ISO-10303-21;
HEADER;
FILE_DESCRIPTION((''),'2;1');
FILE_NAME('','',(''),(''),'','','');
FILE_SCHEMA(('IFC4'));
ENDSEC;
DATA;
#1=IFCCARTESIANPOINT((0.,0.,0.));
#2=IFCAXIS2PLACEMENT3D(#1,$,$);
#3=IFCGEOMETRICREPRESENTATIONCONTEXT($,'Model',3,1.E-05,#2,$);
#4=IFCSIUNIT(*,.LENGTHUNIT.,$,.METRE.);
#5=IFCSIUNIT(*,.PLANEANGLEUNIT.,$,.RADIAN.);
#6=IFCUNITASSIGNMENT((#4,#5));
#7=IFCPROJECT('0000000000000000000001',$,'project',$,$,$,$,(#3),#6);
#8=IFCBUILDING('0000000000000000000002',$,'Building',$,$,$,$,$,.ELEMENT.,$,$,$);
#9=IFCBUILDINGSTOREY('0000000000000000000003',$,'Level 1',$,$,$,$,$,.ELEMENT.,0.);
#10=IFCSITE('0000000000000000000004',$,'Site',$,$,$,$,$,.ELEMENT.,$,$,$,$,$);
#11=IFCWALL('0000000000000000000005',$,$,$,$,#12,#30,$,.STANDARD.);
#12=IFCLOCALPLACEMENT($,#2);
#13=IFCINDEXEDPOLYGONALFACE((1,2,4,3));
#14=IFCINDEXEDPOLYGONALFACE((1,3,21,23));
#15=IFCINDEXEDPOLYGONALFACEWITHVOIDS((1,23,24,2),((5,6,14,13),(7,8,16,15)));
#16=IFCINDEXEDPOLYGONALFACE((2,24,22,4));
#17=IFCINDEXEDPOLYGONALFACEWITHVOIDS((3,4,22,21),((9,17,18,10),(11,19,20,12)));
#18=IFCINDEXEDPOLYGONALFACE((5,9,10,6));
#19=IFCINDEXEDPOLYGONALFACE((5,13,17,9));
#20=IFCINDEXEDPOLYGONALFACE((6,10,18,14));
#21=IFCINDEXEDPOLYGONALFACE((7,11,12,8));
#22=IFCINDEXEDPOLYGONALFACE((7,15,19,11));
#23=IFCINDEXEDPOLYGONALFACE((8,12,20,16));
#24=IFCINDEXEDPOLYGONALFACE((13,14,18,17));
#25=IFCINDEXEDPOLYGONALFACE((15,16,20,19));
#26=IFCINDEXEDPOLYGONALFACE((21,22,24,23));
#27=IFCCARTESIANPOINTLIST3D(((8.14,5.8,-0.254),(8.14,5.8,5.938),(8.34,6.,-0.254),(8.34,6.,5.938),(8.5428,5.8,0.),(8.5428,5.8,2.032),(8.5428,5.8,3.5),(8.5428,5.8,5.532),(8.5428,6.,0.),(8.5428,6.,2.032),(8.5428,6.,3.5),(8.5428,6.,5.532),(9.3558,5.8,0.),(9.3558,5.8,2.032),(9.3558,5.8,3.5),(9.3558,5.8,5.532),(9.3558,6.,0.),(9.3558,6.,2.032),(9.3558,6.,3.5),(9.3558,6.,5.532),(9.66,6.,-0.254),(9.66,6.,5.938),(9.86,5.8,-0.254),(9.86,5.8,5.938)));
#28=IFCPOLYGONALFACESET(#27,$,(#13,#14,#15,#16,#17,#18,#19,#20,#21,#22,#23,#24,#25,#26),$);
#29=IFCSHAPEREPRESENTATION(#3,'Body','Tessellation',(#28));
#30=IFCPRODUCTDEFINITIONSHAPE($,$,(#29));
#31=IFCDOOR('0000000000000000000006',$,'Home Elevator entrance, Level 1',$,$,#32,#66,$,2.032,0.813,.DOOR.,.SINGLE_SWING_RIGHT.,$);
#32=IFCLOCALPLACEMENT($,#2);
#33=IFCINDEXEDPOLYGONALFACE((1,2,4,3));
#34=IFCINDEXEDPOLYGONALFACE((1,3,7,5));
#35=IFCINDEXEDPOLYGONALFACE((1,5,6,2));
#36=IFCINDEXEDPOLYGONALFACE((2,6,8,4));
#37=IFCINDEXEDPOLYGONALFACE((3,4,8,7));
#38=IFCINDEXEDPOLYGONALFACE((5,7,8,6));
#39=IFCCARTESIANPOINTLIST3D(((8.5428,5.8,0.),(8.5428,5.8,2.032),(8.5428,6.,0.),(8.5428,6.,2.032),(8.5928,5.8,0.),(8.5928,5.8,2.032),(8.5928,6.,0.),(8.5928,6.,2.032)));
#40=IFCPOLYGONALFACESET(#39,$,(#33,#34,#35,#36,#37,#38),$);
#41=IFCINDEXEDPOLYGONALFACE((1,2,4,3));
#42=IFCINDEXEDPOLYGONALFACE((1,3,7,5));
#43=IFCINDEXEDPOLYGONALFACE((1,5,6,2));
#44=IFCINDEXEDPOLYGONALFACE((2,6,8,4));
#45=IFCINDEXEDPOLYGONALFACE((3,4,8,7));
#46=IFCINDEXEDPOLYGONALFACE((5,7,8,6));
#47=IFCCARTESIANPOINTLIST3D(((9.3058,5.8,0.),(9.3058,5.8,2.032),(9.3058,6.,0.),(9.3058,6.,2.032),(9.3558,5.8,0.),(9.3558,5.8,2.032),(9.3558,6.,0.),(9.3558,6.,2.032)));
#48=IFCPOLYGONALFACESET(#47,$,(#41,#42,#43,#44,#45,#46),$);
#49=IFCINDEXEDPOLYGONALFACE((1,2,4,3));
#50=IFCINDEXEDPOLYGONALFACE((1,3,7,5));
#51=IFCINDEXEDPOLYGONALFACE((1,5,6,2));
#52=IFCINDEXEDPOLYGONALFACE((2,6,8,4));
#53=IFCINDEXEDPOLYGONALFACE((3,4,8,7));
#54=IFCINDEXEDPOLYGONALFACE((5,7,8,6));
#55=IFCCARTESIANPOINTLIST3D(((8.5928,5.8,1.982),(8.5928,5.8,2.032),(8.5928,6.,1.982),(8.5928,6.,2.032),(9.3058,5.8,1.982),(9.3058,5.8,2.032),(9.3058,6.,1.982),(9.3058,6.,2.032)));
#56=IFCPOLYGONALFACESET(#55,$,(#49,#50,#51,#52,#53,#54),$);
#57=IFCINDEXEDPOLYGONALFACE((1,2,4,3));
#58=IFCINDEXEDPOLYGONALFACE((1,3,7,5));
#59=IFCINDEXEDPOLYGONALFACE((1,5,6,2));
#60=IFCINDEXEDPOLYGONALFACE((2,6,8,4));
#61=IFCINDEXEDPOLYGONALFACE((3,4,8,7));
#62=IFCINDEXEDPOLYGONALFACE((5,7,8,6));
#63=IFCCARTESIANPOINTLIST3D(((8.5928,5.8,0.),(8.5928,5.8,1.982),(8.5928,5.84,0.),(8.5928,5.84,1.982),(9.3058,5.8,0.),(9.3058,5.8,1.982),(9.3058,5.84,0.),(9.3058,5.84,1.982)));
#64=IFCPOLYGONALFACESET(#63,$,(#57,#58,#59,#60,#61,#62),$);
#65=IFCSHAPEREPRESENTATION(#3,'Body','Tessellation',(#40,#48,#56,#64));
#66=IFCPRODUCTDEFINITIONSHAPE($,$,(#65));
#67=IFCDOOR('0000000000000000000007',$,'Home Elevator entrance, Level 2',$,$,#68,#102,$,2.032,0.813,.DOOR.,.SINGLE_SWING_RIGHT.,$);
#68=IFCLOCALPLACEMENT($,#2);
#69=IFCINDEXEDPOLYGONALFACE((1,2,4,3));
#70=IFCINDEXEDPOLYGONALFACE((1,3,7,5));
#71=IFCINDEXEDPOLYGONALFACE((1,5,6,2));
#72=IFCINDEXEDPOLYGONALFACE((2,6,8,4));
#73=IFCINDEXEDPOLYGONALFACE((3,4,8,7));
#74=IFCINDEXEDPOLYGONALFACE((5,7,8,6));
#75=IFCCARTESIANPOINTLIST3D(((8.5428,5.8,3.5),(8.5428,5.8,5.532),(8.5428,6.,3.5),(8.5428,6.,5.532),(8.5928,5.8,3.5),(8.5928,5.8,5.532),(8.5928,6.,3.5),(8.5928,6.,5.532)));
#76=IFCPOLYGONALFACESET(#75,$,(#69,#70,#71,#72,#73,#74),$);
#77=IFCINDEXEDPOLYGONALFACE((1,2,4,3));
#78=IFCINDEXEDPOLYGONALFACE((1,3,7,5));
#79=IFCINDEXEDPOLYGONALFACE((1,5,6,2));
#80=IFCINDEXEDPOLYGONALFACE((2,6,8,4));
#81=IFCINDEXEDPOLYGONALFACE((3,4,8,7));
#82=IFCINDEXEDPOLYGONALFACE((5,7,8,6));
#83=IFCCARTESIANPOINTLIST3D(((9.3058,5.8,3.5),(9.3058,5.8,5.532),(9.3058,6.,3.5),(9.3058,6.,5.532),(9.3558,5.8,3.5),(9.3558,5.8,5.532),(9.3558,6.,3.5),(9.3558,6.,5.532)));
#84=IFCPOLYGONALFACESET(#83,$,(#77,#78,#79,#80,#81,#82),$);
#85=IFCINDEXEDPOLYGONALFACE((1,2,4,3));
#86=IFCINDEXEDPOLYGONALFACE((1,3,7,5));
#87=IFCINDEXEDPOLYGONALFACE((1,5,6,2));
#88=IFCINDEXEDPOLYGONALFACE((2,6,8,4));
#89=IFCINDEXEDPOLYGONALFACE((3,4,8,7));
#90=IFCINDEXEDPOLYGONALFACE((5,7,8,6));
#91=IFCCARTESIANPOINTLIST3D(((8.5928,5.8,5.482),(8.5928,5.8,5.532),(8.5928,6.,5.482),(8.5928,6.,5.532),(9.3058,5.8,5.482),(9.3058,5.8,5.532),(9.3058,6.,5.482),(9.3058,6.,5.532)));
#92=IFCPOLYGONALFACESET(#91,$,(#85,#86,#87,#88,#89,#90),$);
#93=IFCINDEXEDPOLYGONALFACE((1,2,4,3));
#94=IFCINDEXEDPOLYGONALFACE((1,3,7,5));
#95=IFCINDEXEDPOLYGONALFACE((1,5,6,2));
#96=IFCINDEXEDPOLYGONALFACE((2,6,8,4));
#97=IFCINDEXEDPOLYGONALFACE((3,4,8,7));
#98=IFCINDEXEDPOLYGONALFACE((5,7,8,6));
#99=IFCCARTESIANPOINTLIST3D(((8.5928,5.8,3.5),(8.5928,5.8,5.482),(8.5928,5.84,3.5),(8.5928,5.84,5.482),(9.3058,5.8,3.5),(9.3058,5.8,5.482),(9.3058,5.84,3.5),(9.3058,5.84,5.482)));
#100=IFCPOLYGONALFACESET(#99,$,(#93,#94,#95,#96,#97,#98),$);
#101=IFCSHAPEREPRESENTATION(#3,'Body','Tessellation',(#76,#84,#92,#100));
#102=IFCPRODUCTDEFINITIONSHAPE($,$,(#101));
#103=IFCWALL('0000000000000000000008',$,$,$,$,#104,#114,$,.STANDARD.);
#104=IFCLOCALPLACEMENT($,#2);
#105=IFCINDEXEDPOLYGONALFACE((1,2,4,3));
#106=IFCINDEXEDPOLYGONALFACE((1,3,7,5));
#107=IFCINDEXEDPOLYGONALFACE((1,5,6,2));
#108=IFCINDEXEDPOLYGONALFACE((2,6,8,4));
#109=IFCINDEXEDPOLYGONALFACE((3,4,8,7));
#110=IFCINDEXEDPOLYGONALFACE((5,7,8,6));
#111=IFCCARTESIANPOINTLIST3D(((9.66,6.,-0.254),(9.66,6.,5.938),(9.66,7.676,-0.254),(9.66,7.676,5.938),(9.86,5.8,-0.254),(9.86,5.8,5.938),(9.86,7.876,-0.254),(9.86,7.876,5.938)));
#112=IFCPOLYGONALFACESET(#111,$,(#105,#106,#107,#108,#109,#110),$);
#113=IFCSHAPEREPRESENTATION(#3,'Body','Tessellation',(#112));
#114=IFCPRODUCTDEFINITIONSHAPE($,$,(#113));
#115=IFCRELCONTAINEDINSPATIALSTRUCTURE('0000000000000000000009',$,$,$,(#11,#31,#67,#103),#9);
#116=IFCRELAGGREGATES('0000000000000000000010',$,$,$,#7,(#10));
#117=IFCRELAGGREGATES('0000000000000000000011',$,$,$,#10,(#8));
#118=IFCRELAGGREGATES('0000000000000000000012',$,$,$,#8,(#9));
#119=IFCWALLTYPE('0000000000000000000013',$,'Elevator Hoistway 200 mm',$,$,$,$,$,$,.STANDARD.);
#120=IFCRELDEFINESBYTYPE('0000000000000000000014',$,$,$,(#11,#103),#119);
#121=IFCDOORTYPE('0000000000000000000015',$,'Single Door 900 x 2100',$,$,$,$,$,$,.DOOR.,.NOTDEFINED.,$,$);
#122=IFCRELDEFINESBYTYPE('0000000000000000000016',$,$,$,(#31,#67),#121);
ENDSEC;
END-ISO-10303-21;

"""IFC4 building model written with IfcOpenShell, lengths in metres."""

from ifc_helpers import new_model, si_unit, frame, frame_2d, origin, origin_with_axes, origin_2d, place, context, project, spatial, polyline, rectangle, outline, extrude, type_object, element, fill, save


model = new_model("IFC4")

# Units and contexts
model_context = context("Model", 3, precision=1e-05, world=origin())
ifc_project = project(units=[si_unit("LENGTHUNIT", "METRE"), si_unit("PLANEANGLEUNIT", "RADIAN")], contexts=[model_context])

# Site, building, storey
site = spatial("IfcSite", under=ifc_project, Name="Site", CompositionType="ELEMENT")
building = spatial("IfcBuilding", under=site, Name="Building", CompositionType="ELEMENT")
storey = spatial("IfcBuildingStorey", under=building, Name="Level 1", CompositionType="ELEMENT", Elevation=0.0)

# Shared definitions
wall_type = type_object("IfcWallType", Name="Elevator Hoistway 200 mm", PredefinedType="STANDARD")

# Shared definitions
door_type = type_object("IfcDoorType", Name="Single Door 900 x 2100", OperationType="NOTDEFINED", PredefinedType="DOOR")

# Wall, openings, doors
wall_1_placement = place(None, frame((8.24, 5.9, -0.254), z_axis=(0.0, 0.0, 1.0), x_axis=(1.0, 0.0, 0.0)))
wall_1 = element("IfcWall", 1, at=wall_1_placement, inside=storey, type_object=wall_type, PredefinedType="STANDARD", context=model_context, shape_type="SweptSolid", body=[
    extrude(outline(polyline([(-0.1, -0.1), (1.62, -0.1), (1.42, 0.1), (0.1, 0.1), (-0.1, -0.1)])), origin(), (0.0, 0.0, 1.0), 6.192),
])
opening_1_placement = place(wall_1_placement, frame((0.7093, 0.0, 0.254), z_axis=(0.0, 0.0, 1.0), x_axis=(1.0, 0.0, 0.0)))
opening_1 = element("IfcOpeningElement", 2, at=opening_1_placement, cuts=wall_1, PredefinedType="OPENING", context=model_context, shape_type="SweptSolid", body=[
    extrude(rectangle(XDim=0.813, YDim=0.202, at=origin_2d()), origin(), (0.0, 0.0, 1.0), 2.032),
])
opening_2_placement = place(wall_1_placement, frame((0.7093, 0.0, 3.754), z_axis=(0.0, 0.0, 1.0), x_axis=(1.0, 0.0, 0.0)))
opening_2 = element("IfcOpeningElement", 3, at=opening_2_placement, cuts=wall_1, PredefinedType="OPENING", context=model_context, shape_type="SweptSolid", body=[
    extrude(rectangle(XDim=0.813, YDim=0.202, at=origin_2d()), origin(), (0.0, 0.0, 1.0), 2.032),
])
door_1_placement = place(opening_1_placement, origin_with_axes())
door_1 = element("IfcDoor", 4, at=door_1_placement, inside=storey, type_object=door_type, Name="Home Elevator entrance, Level 1", OperationType="SINGLE_SWING_RIGHT", OverallHeight=2.032, OverallWidth=0.813, PredefinedType="DOOR", context=model_context, shape_type="SweptSolid", body=[
    extrude(rectangle(XDim=0.05, YDim=0.2, at=frame_2d((-0.3815, 0.0))), origin(), (0.0, 0.0, 1.0), 2.032),
    extrude(rectangle(XDim=0.05, YDim=0.2, at=frame_2d((0.3815, 0.0))), origin(), (0.0, 0.0, 1.0), 2.032),
    extrude(rectangle(XDim=0.713, YDim=0.2, at=origin_2d()), frame((0.0, 0.0, 1.982)), (0.0, 0.0, 1.0), 0.05),
    extrude(rectangle(XDim=0.713, YDim=0.04, at=frame_2d((0.0, -0.08))), origin(), (0.0, 0.0, 1.0), 1.982),
])
fill(opening_1, door_1)
door_2_placement = place(opening_2_placement, origin_with_axes())
door_2 = element("IfcDoor", 5, at=door_2_placement, inside=storey, type_object=door_type, Name="Home Elevator entrance, Level 2", OperationType="SINGLE_SWING_RIGHT", OverallHeight=2.032, OverallWidth=0.813, PredefinedType="DOOR", context=model_context, shape_type="SweptSolid", body=[
    extrude(rectangle(XDim=0.05, YDim=0.2, at=frame_2d((-0.3815, 0.0))), origin(), (0.0, 0.0, 1.0), 2.032),
    extrude(rectangle(XDim=0.05, YDim=0.2, at=frame_2d((0.3815, 0.0))), origin(), (0.0, 0.0, 1.0), 2.032),
    extrude(rectangle(XDim=0.713, YDim=0.2, at=origin_2d()), frame((0.0, 0.0, 1.982)), (0.0, 0.0, 1.0), 0.05),
    extrude(rectangle(XDim=0.713, YDim=0.04, at=frame_2d((0.0, -0.08))), origin(), (0.0, 0.0, 1.0), 1.982),
])
fill(opening_2, door_2)

# Wall
wall_2_placement = place(None, frame((9.76, 5.9, -0.254), z_axis=(0.0, 0.0, 1.0), x_axis=(0.0, 1.0, 0.0)))
element("IfcWall", 6, at=wall_2_placement, inside=storey, type_object=wall_type, PredefinedType="STANDARD", context=model_context, shape_type="SweptSolid", body=[
    extrude(outline(polyline([(-0.1, -0.1), (1.976, -0.1), (1.776, 0.1), (0.1, 0.1), (-0.1, -0.1)])), origin(), (0.0, 0.0, 1.0), 6.192),
])

save(model, "model.ifc")
